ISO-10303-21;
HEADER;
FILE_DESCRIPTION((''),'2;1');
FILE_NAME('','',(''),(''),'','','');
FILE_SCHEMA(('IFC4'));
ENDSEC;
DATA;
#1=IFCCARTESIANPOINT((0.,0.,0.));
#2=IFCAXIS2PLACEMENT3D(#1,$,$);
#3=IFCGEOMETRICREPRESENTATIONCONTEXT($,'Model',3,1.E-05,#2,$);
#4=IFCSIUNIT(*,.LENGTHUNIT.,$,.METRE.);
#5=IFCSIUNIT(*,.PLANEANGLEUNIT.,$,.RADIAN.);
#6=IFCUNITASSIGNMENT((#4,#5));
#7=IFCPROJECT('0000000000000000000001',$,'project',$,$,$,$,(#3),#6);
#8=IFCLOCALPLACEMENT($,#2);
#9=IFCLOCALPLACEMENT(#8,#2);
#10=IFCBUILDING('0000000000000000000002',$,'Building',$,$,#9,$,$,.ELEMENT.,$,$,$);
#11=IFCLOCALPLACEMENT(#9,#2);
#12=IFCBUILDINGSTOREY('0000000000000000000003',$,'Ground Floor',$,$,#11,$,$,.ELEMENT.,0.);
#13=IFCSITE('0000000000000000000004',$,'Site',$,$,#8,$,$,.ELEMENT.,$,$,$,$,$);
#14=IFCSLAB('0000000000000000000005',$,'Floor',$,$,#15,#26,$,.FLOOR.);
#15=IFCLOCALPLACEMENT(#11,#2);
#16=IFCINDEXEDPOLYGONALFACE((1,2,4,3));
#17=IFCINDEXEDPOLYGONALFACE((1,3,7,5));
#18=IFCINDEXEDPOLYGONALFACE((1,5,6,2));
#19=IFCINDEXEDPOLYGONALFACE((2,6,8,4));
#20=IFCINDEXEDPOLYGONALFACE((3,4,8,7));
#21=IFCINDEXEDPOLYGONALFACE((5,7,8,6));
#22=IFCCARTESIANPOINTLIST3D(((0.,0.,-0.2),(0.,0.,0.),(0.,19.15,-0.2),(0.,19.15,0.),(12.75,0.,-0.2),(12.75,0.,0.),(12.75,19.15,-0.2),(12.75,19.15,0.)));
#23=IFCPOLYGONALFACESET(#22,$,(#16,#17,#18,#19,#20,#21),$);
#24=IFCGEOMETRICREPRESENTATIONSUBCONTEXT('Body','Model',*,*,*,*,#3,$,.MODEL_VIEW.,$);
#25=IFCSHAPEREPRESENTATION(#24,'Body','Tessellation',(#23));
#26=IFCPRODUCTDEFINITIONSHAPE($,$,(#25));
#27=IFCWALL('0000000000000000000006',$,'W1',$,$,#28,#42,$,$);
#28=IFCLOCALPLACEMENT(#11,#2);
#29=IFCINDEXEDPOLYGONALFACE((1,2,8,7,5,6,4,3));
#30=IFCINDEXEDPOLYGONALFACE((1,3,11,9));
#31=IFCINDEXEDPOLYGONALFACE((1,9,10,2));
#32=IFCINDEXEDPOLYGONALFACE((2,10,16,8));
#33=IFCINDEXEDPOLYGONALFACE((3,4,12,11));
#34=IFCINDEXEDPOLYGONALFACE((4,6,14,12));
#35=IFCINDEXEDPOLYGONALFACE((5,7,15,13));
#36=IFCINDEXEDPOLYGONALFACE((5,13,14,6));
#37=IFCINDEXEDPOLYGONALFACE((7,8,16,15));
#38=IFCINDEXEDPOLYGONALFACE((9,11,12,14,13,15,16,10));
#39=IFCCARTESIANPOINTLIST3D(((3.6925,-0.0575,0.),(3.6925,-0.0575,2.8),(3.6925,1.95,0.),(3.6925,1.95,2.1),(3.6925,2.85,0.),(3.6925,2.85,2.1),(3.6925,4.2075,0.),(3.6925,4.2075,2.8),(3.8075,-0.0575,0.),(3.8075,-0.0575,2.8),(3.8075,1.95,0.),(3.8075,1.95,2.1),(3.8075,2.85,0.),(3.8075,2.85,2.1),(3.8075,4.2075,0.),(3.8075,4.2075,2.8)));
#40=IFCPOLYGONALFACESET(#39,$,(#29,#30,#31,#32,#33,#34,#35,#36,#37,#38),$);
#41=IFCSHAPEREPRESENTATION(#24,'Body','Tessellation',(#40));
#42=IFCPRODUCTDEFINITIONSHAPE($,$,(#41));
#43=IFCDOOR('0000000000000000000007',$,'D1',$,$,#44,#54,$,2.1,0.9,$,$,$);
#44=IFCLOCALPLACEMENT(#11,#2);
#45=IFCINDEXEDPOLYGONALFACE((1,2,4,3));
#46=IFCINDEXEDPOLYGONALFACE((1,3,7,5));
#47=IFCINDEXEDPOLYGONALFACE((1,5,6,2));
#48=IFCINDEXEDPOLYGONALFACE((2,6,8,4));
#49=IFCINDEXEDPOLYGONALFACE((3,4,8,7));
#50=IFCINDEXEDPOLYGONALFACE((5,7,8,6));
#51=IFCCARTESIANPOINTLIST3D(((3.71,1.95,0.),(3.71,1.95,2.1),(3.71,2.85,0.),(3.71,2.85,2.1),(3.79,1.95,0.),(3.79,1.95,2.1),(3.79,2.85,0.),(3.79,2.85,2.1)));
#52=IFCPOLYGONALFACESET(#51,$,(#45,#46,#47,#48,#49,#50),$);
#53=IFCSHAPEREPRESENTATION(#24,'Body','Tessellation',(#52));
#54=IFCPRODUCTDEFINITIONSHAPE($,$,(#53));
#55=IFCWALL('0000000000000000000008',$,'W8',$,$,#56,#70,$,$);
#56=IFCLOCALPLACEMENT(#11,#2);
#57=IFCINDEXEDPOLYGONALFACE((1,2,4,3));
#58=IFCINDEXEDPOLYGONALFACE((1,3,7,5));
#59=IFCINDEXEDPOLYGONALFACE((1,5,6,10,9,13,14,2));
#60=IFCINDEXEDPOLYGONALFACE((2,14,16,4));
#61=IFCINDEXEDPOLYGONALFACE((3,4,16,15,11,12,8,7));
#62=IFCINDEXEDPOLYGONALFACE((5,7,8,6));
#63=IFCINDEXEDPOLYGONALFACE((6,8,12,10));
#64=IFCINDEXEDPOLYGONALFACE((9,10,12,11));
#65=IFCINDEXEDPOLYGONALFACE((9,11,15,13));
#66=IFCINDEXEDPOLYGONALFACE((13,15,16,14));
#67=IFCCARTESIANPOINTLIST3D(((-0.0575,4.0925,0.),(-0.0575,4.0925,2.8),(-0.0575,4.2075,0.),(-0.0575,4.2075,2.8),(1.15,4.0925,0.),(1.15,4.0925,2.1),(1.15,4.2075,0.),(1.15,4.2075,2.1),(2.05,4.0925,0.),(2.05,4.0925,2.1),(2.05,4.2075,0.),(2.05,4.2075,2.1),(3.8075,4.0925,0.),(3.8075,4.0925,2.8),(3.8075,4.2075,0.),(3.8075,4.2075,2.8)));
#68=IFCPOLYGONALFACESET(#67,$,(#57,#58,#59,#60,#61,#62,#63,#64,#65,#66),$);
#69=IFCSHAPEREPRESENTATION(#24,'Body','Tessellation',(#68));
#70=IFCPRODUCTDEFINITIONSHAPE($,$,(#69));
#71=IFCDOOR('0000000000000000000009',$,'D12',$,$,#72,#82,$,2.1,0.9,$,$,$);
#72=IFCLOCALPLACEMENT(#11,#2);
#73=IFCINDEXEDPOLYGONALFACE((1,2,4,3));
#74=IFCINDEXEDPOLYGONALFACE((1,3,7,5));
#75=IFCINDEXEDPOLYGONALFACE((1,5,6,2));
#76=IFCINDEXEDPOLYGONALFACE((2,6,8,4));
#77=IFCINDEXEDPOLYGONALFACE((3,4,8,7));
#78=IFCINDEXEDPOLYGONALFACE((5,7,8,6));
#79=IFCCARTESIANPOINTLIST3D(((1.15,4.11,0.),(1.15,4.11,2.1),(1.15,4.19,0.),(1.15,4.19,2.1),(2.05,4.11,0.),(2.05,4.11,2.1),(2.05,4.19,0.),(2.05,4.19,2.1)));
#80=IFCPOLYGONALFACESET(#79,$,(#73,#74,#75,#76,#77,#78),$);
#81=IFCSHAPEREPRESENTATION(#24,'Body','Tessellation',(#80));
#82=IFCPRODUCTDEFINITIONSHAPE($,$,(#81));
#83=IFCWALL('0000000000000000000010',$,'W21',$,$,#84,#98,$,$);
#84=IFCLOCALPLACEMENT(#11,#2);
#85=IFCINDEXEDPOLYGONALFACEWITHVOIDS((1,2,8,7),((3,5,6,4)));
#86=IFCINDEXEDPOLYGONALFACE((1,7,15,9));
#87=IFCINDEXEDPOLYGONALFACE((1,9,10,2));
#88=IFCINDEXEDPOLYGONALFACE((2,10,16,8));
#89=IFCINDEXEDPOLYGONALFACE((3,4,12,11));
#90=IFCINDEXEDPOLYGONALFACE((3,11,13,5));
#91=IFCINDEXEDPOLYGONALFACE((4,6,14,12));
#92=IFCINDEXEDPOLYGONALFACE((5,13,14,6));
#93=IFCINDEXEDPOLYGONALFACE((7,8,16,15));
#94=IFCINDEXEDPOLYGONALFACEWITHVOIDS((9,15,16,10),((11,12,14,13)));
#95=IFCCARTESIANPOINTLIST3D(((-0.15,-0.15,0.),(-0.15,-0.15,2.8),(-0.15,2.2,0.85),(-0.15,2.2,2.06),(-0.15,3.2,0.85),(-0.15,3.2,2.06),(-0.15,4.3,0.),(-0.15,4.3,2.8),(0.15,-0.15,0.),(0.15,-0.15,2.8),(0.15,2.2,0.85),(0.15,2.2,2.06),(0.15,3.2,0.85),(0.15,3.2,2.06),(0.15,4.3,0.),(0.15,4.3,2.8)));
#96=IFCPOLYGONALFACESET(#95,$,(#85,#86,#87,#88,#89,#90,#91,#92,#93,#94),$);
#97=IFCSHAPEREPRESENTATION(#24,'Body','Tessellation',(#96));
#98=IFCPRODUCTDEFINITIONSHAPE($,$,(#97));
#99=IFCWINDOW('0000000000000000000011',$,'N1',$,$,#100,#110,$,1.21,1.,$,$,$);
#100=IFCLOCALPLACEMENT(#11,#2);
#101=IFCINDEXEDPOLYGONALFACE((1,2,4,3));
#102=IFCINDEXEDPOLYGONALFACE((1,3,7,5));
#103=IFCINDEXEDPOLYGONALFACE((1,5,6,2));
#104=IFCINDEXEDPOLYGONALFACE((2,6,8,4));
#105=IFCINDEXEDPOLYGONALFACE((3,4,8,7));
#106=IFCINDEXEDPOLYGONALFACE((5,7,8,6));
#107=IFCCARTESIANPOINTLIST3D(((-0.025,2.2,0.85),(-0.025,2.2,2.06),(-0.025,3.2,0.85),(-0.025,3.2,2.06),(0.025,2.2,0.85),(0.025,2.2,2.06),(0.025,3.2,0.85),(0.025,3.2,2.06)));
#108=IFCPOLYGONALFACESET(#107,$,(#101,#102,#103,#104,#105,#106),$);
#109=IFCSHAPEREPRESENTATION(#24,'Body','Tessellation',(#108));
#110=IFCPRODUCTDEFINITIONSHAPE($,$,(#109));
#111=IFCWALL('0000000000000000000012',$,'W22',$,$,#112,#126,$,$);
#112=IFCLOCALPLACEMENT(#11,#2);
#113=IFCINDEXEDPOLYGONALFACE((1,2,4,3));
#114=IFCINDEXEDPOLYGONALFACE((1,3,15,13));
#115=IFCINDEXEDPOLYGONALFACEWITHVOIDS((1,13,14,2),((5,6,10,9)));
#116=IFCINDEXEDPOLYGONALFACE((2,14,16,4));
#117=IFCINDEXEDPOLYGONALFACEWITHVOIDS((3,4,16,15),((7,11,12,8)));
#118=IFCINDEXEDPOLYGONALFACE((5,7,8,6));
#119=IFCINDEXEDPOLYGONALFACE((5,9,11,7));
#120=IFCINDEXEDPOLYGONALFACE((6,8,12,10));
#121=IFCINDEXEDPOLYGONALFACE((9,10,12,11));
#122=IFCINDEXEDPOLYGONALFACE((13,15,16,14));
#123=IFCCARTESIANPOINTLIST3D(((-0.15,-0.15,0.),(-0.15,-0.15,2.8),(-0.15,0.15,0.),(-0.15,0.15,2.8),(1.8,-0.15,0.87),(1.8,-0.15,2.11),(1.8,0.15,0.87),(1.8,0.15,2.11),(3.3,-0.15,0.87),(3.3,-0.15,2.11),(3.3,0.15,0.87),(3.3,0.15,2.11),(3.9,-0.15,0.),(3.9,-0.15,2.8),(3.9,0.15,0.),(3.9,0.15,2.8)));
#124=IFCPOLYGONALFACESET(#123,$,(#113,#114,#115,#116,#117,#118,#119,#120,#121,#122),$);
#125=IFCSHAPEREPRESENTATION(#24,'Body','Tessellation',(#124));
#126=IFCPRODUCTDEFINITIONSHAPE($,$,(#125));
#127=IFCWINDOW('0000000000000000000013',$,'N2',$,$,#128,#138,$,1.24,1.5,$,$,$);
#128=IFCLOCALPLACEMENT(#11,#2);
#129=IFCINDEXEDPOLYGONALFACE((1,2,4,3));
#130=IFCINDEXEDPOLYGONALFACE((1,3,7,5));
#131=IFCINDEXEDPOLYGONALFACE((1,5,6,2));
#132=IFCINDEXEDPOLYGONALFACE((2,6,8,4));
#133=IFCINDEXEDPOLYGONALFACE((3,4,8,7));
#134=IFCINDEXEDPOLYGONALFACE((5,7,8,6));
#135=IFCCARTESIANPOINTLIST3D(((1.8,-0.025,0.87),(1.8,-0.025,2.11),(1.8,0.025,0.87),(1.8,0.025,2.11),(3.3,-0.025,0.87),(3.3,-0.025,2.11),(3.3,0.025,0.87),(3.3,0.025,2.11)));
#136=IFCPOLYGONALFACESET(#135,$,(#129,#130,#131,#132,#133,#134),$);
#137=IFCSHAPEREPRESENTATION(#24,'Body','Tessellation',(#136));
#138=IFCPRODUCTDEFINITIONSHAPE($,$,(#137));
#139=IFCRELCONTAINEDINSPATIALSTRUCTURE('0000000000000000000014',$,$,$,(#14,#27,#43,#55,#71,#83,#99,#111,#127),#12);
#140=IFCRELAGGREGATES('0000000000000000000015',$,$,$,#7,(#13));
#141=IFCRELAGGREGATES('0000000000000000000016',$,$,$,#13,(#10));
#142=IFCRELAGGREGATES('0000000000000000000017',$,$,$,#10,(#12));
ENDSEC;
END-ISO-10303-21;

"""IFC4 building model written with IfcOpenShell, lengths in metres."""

from ifc_helpers import new_model, si_unit, frame, frame_2d, origin, origin_2d, place, context, subcontext, project, spatial, polyline, rectangle, outline, extrude, element, fill, save


model = new_model("IFC4")

# Units and contexts
model_context = context("Model", 3, precision=1e-05, world=origin())
body_context = subcontext(model_context, "Body", "Model", "MODEL_VIEW")
ifc_project = project(units=[si_unit("LENGTHUNIT", "METRE"), si_unit("PLANEANGLEUNIT", "RADIAN")], contexts=[model_context])

# Site, building, storey
site_placement = place(None, origin())
site = spatial("IfcSite", under=ifc_project, at=site_placement, Name="Site", CompositionType="ELEMENT")
building_placement = place(site_placement, origin())
building = spatial("IfcBuilding", under=site, at=building_placement, Name="Building", CompositionType="ELEMENT")
storey_placement = place(building_placement, origin())
storey = spatial("IfcBuildingStorey", under=building, at=storey_placement, Name="Ground Floor", CompositionType="ELEMENT", Elevation=0.0)

# Slab
slab_placement = place(storey_placement, origin())
element("IfcSlab", 1, at=slab_placement, inside=storey, Name="Floor", PredefinedType="FLOOR", context=body_context, shape_type="SweptSolid", body=[
    extrude(outline(polyline([(0.0, 0.0), (12.75, 0.0), (12.75, 19.15), (0.0, 19.15), (0.0, 0.0)])), origin(), (0.0, 0.0, -1.0), 0.2),
])

# Walls, openings, doors
wall_1_placement = place(storey_placement, frame((3.75, 0.0, 0.0), x_axis=(0.0, 1.0, 0.0)))
wall_1 = element("IfcWall", 2, at=wall_1_placement, inside=storey, Name="W1", context=body_context, shape_type="SweptSolid", body=[
    extrude(rectangle(XDim=4.265, YDim=0.115, at=frame_2d((2.075, 0.0))), origin(), (0.0, 0.0, 1.0), 2.8),
])
opening_1_placement = place(wall_1_placement, frame((2.4, 0.0, 0.0)))
opening_1 = element("IfcOpeningElement", 3, at=opening_1_placement, cuts=wall_1, context=body_context, shape_type="SweptSolid", body=[
    extrude(rectangle(XDim=0.9, YDim=0.215, at=origin_2d()), origin(), (0.0, 0.0, 1.0), 2.1),
])
door_1_placement = place(opening_1_placement, origin())
door_1 = element("IfcDoor", 4, at=door_1_placement, inside=storey, Name="D1", OverallHeight=2.1, OverallWidth=0.9, context=body_context, shape_type="SweptSolid", body=[
    extrude(rectangle(XDim=0.9, YDim=0.08, at=origin_2d()), origin(), (0.0, 0.0, 1.0), 2.1),
])
fill(opening_1, door_1)
wall_2_placement = place(storey_placement, frame((0.0, 4.15, 0.0), x_axis=(1.0, 0.0, 0.0)))
wall_2 = element("IfcWall", 5, at=wall_2_placement, inside=storey, Name="W8", context=body_context, shape_type="SweptSolid", body=[
    extrude(rectangle(XDim=3.865, YDim=0.115, at=frame_2d((1.875, 0.0))), origin(), (0.0, 0.0, 1.0), 2.8),
])
opening_2_placement = place(wall_2_placement, frame((1.6, 0.0, 0.0)))
opening_2 = element("IfcOpeningElement", 6, at=opening_2_placement, cuts=wall_2, context=body_context, shape_type="SweptSolid", body=[
    extrude(rectangle(XDim=0.9, YDim=0.215, at=origin_2d()), origin(), (0.0, 0.0, 1.0), 2.1),
])
door_2_placement = place(opening_2_placement, origin())
door_2 = element("IfcDoor", 7, at=door_2_placement, inside=storey, Name="D12", OverallHeight=2.1, OverallWidth=0.9, context=body_context, shape_type="SweptSolid", body=[
    extrude(rectangle(XDim=0.9, YDim=0.08, at=origin_2d()), origin(), (0.0, 0.0, 1.0), 2.1),
])
fill(opening_2, door_2)

# Walls, openings, windows
wall_3_placement = place(storey_placement, frame((0.0, 0.0, 0.0), x_axis=(0.0, 1.0, 0.0)))
wall_3 = element("IfcWall", 8, at=wall_3_placement, inside=storey, Name="W21", context=body_context, shape_type="SweptSolid", body=[
    extrude(rectangle(XDim=4.45, YDim=0.3, at=frame_2d((2.075, 0.0))), origin(), (0.0, 0.0, 1.0), 2.8),
])
opening_3_placement = place(wall_3_placement, frame((2.7, 0.0, 0.85)))
opening_3 = element("IfcOpeningElement", 9, at=opening_3_placement, cuts=wall_3, context=body_context, shape_type="SweptSolid", body=[
    extrude(rectangle(XDim=1.0, YDim=0.4, at=origin_2d()), origin(), (0.0, 0.0, 1.0), 1.21),
])
window_1_placement = place(opening_3_placement, origin())
window_1 = element("IfcWindow", 10, at=window_1_placement, inside=storey, Name="N1", OverallHeight=1.21, OverallWidth=1.0, context=body_context, shape_type="SweptSolid", body=[
    extrude(rectangle(XDim=1.0, YDim=0.05, at=origin_2d()), origin(), (0.0, 0.0, 1.0), 1.21),
])
fill(opening_3, window_1)
wall_4_placement = place(storey_placement, frame((0.0, 0.0, 0.0), x_axis=(1.0, 0.0, 0.0)))
wall_4 = element("IfcWall", 11, at=wall_4_placement, inside=storey, Name="W22", context=body_context, shape_type="SweptSolid", body=[
    extrude(rectangle(XDim=4.05, YDim=0.3, at=frame_2d((1.875, 0.0))), origin(), (0.0, 0.0, 1.0), 2.8),
])
opening_4_placement = place(wall_4_placement, frame((2.55, 0.0, 0.87)))
opening_4 = element("IfcOpeningElement", 12, at=opening_4_placement, cuts=wall_4, context=body_context, shape_type="SweptSolid", body=[
    extrude(rectangle(XDim=1.5, YDim=0.4, at=origin_2d()), origin(), (0.0, 0.0, 1.0), 1.24),
])
window_2_placement = place(opening_4_placement, origin())
window_2 = element("IfcWindow", 13, at=window_2_placement, inside=storey, Name="N2", OverallHeight=1.24, OverallWidth=1.5, context=body_context, shape_type="SweptSolid", body=[
    extrude(rectangle(XDim=1.5, YDim=0.05, at=origin_2d()), origin(), (0.0, 0.0, 1.0), 1.24),
])
fill(opening_4, window_2)

save(model, "model.ifc")
